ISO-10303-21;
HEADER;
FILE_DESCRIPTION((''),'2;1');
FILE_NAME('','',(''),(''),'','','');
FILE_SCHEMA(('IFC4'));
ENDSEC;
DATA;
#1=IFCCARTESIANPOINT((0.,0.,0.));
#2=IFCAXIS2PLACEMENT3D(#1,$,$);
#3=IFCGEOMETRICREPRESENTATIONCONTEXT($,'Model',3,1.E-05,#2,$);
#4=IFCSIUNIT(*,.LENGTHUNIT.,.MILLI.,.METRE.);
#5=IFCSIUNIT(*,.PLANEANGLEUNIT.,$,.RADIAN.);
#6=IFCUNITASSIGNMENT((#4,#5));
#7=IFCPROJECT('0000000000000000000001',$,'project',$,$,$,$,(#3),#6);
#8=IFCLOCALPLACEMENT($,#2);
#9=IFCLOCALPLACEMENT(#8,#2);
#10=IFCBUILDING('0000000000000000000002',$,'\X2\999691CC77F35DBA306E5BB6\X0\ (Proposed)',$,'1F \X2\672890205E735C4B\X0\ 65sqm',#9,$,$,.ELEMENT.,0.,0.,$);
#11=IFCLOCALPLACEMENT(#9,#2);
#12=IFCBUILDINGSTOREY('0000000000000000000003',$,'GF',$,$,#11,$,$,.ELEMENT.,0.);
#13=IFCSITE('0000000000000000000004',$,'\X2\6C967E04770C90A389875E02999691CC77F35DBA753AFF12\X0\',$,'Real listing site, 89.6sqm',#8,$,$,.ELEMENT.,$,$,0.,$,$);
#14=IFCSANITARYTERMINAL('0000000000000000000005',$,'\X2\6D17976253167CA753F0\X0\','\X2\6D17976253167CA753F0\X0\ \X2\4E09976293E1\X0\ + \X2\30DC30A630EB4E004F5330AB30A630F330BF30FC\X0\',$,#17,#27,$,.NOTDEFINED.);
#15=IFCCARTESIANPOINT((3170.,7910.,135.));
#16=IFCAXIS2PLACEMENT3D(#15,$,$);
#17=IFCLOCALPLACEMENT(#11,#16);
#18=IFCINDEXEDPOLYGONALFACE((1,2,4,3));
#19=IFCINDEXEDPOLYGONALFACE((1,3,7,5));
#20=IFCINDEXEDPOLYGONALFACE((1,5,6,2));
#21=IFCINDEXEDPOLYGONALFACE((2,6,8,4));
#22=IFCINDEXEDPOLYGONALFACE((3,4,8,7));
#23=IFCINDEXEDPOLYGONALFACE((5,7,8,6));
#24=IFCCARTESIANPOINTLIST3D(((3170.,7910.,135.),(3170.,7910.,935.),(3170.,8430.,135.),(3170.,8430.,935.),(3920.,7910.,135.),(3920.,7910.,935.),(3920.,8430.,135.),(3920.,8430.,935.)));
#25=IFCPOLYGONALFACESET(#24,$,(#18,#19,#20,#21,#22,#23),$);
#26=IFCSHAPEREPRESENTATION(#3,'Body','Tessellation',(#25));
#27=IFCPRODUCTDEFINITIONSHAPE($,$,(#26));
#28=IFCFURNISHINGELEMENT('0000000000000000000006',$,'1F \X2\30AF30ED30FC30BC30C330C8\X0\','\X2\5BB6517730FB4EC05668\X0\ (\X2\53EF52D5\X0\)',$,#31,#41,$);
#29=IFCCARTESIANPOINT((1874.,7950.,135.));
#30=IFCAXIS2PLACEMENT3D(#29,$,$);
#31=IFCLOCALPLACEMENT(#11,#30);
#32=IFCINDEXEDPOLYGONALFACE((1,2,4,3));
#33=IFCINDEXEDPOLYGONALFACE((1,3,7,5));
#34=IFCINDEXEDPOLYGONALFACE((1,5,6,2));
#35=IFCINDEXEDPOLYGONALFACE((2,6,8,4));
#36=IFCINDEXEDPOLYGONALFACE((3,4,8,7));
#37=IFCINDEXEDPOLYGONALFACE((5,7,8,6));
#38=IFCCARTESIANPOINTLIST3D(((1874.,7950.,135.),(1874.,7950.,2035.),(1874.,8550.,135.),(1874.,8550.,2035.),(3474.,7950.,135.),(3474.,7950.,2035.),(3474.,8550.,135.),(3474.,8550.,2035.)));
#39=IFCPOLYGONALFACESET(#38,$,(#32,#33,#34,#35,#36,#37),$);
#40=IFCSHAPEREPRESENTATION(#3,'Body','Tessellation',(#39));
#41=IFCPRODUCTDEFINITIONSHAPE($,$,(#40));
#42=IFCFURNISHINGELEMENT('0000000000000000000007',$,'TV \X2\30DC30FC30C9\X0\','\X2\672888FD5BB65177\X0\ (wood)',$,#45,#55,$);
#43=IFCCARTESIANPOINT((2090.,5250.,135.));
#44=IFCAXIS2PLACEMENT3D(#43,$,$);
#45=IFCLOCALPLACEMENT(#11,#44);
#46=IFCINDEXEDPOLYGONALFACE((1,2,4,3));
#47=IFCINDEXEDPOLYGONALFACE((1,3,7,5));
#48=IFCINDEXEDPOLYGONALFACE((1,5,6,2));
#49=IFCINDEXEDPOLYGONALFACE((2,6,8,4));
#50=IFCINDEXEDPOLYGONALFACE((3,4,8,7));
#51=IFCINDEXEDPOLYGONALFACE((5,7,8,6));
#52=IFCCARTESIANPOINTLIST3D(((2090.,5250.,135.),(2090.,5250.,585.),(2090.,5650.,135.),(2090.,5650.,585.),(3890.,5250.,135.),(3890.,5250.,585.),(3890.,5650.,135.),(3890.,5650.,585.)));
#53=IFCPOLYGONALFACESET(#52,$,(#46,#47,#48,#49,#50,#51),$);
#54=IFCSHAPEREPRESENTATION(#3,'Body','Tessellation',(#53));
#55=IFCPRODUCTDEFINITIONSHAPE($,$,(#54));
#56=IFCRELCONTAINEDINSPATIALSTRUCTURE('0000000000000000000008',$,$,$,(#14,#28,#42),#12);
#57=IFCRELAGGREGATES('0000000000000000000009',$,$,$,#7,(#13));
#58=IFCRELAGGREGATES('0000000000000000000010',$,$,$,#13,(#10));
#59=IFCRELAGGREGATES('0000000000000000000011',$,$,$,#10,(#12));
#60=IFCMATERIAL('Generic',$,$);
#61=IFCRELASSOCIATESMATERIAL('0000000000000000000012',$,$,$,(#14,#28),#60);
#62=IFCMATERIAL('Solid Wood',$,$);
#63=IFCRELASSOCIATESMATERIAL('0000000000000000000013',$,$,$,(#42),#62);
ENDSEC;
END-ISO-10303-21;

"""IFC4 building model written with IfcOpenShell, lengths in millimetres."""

from ifc_helpers import new_model, si_unit, frame, frame_2d, origin, place, context, project, spatial, rectangle, extrude, material, element, save


model = new_model("IFC4")

# Units and contexts
model_context = context("Model", 3, precision=1e-05, world=origin())
ifc_project = project(units=[si_unit("LENGTHUNIT", "METRE", prefix="MILLI"), si_unit("PLANEANGLEUNIT", "RADIAN")], contexts=[model_context])

# Site, building, storey
site_placement = place(None, origin())
site = spatial("IfcSite", under=ifc_project, at=site_placement, Name="沖縄県那覇市首里石嶺町２", ObjectType="Real listing site, 89.6sqm", CompositionType="ELEMENT", RefElevation=0.0)
building_placement = place(site_placement, origin())
building = spatial("IfcBuilding", under=site, at=building_placement, Name="首里石嶺の家 (Proposed)", ObjectType="1F 木造平屋 65sqm", CompositionType="ELEMENT", ElevationOfRefHeight=0.0, ElevationOfTerrain=0.0)
storey_placement = place(building_placement, origin())
storey = spatial("IfcBuildingStorey", under=building, at=storey_placement, Name="GF", CompositionType="ELEMENT", Elevation=0.0)

# Shared definitions
ifc_material_1 = material(Name="Solid Wood")

# Shared definitions
ifc_material_2 = material(Name="Generic")

# Sanitary terminal
sanitary_terminal_1_placement = place(storey_placement, frame((3170.0, 7910.0, 135.0)))
element("IfcSanitaryTerminal", 1, at=sanitary_terminal_1_placement, inside=storey, material=ifc_material_2, Name="洗面化粧台", Description="洗面化粧台 三面鏡 + ボウル一体カウンター", PredefinedType="NOTDEFINED", context=model_context, shape_type="SweptSolid", body=[
    extrude(rectangle(XDim=750.0, YDim=520.0, at=frame_2d((375.0, 260.0))), frame((3170.0, 7910.0, 135.0)), (0.0, 0.0, 1.0), 800.0),
])

# Furnishing elements
furnishing_1_placement = place(storey_placement, frame((1874.0, 7950.0, 135.0)))
element("IfcFurnishingElement", 2, at=furnishing_1_placement, inside=storey, material=ifc_material_2, Name="1F クローゼット", Description="家具・什器 (可動)", context=model_context, shape_type="SweptSolid", body=[
    extrude(rectangle(XDim=1600.0, YDim=600.0, at=frame_2d((800.0, 300.0))), frame((1874.0, 7950.0, 135.0)), (0.0, 0.0, 1.0), 1900.0),
])
furnishing_2_placement = place(storey_placement, frame((2090.0, 5250.0, 135.0)))
element("IfcFurnishingElement", 3, at=furnishing_2_placement, inside=storey, material=ifc_material_1, Name="TV ボード", Description="木製家具 (wood)", context=model_context, shape_type="SweptSolid", body=[
    extrude(rectangle(XDim=1800.0, YDim=400.0, at=frame_2d((900.0, 200.0))), frame((2090.0, 5250.0, 135.0)), (0.0, 0.0, 1.0), 450.0),
])

save(model, "model.ifc")
